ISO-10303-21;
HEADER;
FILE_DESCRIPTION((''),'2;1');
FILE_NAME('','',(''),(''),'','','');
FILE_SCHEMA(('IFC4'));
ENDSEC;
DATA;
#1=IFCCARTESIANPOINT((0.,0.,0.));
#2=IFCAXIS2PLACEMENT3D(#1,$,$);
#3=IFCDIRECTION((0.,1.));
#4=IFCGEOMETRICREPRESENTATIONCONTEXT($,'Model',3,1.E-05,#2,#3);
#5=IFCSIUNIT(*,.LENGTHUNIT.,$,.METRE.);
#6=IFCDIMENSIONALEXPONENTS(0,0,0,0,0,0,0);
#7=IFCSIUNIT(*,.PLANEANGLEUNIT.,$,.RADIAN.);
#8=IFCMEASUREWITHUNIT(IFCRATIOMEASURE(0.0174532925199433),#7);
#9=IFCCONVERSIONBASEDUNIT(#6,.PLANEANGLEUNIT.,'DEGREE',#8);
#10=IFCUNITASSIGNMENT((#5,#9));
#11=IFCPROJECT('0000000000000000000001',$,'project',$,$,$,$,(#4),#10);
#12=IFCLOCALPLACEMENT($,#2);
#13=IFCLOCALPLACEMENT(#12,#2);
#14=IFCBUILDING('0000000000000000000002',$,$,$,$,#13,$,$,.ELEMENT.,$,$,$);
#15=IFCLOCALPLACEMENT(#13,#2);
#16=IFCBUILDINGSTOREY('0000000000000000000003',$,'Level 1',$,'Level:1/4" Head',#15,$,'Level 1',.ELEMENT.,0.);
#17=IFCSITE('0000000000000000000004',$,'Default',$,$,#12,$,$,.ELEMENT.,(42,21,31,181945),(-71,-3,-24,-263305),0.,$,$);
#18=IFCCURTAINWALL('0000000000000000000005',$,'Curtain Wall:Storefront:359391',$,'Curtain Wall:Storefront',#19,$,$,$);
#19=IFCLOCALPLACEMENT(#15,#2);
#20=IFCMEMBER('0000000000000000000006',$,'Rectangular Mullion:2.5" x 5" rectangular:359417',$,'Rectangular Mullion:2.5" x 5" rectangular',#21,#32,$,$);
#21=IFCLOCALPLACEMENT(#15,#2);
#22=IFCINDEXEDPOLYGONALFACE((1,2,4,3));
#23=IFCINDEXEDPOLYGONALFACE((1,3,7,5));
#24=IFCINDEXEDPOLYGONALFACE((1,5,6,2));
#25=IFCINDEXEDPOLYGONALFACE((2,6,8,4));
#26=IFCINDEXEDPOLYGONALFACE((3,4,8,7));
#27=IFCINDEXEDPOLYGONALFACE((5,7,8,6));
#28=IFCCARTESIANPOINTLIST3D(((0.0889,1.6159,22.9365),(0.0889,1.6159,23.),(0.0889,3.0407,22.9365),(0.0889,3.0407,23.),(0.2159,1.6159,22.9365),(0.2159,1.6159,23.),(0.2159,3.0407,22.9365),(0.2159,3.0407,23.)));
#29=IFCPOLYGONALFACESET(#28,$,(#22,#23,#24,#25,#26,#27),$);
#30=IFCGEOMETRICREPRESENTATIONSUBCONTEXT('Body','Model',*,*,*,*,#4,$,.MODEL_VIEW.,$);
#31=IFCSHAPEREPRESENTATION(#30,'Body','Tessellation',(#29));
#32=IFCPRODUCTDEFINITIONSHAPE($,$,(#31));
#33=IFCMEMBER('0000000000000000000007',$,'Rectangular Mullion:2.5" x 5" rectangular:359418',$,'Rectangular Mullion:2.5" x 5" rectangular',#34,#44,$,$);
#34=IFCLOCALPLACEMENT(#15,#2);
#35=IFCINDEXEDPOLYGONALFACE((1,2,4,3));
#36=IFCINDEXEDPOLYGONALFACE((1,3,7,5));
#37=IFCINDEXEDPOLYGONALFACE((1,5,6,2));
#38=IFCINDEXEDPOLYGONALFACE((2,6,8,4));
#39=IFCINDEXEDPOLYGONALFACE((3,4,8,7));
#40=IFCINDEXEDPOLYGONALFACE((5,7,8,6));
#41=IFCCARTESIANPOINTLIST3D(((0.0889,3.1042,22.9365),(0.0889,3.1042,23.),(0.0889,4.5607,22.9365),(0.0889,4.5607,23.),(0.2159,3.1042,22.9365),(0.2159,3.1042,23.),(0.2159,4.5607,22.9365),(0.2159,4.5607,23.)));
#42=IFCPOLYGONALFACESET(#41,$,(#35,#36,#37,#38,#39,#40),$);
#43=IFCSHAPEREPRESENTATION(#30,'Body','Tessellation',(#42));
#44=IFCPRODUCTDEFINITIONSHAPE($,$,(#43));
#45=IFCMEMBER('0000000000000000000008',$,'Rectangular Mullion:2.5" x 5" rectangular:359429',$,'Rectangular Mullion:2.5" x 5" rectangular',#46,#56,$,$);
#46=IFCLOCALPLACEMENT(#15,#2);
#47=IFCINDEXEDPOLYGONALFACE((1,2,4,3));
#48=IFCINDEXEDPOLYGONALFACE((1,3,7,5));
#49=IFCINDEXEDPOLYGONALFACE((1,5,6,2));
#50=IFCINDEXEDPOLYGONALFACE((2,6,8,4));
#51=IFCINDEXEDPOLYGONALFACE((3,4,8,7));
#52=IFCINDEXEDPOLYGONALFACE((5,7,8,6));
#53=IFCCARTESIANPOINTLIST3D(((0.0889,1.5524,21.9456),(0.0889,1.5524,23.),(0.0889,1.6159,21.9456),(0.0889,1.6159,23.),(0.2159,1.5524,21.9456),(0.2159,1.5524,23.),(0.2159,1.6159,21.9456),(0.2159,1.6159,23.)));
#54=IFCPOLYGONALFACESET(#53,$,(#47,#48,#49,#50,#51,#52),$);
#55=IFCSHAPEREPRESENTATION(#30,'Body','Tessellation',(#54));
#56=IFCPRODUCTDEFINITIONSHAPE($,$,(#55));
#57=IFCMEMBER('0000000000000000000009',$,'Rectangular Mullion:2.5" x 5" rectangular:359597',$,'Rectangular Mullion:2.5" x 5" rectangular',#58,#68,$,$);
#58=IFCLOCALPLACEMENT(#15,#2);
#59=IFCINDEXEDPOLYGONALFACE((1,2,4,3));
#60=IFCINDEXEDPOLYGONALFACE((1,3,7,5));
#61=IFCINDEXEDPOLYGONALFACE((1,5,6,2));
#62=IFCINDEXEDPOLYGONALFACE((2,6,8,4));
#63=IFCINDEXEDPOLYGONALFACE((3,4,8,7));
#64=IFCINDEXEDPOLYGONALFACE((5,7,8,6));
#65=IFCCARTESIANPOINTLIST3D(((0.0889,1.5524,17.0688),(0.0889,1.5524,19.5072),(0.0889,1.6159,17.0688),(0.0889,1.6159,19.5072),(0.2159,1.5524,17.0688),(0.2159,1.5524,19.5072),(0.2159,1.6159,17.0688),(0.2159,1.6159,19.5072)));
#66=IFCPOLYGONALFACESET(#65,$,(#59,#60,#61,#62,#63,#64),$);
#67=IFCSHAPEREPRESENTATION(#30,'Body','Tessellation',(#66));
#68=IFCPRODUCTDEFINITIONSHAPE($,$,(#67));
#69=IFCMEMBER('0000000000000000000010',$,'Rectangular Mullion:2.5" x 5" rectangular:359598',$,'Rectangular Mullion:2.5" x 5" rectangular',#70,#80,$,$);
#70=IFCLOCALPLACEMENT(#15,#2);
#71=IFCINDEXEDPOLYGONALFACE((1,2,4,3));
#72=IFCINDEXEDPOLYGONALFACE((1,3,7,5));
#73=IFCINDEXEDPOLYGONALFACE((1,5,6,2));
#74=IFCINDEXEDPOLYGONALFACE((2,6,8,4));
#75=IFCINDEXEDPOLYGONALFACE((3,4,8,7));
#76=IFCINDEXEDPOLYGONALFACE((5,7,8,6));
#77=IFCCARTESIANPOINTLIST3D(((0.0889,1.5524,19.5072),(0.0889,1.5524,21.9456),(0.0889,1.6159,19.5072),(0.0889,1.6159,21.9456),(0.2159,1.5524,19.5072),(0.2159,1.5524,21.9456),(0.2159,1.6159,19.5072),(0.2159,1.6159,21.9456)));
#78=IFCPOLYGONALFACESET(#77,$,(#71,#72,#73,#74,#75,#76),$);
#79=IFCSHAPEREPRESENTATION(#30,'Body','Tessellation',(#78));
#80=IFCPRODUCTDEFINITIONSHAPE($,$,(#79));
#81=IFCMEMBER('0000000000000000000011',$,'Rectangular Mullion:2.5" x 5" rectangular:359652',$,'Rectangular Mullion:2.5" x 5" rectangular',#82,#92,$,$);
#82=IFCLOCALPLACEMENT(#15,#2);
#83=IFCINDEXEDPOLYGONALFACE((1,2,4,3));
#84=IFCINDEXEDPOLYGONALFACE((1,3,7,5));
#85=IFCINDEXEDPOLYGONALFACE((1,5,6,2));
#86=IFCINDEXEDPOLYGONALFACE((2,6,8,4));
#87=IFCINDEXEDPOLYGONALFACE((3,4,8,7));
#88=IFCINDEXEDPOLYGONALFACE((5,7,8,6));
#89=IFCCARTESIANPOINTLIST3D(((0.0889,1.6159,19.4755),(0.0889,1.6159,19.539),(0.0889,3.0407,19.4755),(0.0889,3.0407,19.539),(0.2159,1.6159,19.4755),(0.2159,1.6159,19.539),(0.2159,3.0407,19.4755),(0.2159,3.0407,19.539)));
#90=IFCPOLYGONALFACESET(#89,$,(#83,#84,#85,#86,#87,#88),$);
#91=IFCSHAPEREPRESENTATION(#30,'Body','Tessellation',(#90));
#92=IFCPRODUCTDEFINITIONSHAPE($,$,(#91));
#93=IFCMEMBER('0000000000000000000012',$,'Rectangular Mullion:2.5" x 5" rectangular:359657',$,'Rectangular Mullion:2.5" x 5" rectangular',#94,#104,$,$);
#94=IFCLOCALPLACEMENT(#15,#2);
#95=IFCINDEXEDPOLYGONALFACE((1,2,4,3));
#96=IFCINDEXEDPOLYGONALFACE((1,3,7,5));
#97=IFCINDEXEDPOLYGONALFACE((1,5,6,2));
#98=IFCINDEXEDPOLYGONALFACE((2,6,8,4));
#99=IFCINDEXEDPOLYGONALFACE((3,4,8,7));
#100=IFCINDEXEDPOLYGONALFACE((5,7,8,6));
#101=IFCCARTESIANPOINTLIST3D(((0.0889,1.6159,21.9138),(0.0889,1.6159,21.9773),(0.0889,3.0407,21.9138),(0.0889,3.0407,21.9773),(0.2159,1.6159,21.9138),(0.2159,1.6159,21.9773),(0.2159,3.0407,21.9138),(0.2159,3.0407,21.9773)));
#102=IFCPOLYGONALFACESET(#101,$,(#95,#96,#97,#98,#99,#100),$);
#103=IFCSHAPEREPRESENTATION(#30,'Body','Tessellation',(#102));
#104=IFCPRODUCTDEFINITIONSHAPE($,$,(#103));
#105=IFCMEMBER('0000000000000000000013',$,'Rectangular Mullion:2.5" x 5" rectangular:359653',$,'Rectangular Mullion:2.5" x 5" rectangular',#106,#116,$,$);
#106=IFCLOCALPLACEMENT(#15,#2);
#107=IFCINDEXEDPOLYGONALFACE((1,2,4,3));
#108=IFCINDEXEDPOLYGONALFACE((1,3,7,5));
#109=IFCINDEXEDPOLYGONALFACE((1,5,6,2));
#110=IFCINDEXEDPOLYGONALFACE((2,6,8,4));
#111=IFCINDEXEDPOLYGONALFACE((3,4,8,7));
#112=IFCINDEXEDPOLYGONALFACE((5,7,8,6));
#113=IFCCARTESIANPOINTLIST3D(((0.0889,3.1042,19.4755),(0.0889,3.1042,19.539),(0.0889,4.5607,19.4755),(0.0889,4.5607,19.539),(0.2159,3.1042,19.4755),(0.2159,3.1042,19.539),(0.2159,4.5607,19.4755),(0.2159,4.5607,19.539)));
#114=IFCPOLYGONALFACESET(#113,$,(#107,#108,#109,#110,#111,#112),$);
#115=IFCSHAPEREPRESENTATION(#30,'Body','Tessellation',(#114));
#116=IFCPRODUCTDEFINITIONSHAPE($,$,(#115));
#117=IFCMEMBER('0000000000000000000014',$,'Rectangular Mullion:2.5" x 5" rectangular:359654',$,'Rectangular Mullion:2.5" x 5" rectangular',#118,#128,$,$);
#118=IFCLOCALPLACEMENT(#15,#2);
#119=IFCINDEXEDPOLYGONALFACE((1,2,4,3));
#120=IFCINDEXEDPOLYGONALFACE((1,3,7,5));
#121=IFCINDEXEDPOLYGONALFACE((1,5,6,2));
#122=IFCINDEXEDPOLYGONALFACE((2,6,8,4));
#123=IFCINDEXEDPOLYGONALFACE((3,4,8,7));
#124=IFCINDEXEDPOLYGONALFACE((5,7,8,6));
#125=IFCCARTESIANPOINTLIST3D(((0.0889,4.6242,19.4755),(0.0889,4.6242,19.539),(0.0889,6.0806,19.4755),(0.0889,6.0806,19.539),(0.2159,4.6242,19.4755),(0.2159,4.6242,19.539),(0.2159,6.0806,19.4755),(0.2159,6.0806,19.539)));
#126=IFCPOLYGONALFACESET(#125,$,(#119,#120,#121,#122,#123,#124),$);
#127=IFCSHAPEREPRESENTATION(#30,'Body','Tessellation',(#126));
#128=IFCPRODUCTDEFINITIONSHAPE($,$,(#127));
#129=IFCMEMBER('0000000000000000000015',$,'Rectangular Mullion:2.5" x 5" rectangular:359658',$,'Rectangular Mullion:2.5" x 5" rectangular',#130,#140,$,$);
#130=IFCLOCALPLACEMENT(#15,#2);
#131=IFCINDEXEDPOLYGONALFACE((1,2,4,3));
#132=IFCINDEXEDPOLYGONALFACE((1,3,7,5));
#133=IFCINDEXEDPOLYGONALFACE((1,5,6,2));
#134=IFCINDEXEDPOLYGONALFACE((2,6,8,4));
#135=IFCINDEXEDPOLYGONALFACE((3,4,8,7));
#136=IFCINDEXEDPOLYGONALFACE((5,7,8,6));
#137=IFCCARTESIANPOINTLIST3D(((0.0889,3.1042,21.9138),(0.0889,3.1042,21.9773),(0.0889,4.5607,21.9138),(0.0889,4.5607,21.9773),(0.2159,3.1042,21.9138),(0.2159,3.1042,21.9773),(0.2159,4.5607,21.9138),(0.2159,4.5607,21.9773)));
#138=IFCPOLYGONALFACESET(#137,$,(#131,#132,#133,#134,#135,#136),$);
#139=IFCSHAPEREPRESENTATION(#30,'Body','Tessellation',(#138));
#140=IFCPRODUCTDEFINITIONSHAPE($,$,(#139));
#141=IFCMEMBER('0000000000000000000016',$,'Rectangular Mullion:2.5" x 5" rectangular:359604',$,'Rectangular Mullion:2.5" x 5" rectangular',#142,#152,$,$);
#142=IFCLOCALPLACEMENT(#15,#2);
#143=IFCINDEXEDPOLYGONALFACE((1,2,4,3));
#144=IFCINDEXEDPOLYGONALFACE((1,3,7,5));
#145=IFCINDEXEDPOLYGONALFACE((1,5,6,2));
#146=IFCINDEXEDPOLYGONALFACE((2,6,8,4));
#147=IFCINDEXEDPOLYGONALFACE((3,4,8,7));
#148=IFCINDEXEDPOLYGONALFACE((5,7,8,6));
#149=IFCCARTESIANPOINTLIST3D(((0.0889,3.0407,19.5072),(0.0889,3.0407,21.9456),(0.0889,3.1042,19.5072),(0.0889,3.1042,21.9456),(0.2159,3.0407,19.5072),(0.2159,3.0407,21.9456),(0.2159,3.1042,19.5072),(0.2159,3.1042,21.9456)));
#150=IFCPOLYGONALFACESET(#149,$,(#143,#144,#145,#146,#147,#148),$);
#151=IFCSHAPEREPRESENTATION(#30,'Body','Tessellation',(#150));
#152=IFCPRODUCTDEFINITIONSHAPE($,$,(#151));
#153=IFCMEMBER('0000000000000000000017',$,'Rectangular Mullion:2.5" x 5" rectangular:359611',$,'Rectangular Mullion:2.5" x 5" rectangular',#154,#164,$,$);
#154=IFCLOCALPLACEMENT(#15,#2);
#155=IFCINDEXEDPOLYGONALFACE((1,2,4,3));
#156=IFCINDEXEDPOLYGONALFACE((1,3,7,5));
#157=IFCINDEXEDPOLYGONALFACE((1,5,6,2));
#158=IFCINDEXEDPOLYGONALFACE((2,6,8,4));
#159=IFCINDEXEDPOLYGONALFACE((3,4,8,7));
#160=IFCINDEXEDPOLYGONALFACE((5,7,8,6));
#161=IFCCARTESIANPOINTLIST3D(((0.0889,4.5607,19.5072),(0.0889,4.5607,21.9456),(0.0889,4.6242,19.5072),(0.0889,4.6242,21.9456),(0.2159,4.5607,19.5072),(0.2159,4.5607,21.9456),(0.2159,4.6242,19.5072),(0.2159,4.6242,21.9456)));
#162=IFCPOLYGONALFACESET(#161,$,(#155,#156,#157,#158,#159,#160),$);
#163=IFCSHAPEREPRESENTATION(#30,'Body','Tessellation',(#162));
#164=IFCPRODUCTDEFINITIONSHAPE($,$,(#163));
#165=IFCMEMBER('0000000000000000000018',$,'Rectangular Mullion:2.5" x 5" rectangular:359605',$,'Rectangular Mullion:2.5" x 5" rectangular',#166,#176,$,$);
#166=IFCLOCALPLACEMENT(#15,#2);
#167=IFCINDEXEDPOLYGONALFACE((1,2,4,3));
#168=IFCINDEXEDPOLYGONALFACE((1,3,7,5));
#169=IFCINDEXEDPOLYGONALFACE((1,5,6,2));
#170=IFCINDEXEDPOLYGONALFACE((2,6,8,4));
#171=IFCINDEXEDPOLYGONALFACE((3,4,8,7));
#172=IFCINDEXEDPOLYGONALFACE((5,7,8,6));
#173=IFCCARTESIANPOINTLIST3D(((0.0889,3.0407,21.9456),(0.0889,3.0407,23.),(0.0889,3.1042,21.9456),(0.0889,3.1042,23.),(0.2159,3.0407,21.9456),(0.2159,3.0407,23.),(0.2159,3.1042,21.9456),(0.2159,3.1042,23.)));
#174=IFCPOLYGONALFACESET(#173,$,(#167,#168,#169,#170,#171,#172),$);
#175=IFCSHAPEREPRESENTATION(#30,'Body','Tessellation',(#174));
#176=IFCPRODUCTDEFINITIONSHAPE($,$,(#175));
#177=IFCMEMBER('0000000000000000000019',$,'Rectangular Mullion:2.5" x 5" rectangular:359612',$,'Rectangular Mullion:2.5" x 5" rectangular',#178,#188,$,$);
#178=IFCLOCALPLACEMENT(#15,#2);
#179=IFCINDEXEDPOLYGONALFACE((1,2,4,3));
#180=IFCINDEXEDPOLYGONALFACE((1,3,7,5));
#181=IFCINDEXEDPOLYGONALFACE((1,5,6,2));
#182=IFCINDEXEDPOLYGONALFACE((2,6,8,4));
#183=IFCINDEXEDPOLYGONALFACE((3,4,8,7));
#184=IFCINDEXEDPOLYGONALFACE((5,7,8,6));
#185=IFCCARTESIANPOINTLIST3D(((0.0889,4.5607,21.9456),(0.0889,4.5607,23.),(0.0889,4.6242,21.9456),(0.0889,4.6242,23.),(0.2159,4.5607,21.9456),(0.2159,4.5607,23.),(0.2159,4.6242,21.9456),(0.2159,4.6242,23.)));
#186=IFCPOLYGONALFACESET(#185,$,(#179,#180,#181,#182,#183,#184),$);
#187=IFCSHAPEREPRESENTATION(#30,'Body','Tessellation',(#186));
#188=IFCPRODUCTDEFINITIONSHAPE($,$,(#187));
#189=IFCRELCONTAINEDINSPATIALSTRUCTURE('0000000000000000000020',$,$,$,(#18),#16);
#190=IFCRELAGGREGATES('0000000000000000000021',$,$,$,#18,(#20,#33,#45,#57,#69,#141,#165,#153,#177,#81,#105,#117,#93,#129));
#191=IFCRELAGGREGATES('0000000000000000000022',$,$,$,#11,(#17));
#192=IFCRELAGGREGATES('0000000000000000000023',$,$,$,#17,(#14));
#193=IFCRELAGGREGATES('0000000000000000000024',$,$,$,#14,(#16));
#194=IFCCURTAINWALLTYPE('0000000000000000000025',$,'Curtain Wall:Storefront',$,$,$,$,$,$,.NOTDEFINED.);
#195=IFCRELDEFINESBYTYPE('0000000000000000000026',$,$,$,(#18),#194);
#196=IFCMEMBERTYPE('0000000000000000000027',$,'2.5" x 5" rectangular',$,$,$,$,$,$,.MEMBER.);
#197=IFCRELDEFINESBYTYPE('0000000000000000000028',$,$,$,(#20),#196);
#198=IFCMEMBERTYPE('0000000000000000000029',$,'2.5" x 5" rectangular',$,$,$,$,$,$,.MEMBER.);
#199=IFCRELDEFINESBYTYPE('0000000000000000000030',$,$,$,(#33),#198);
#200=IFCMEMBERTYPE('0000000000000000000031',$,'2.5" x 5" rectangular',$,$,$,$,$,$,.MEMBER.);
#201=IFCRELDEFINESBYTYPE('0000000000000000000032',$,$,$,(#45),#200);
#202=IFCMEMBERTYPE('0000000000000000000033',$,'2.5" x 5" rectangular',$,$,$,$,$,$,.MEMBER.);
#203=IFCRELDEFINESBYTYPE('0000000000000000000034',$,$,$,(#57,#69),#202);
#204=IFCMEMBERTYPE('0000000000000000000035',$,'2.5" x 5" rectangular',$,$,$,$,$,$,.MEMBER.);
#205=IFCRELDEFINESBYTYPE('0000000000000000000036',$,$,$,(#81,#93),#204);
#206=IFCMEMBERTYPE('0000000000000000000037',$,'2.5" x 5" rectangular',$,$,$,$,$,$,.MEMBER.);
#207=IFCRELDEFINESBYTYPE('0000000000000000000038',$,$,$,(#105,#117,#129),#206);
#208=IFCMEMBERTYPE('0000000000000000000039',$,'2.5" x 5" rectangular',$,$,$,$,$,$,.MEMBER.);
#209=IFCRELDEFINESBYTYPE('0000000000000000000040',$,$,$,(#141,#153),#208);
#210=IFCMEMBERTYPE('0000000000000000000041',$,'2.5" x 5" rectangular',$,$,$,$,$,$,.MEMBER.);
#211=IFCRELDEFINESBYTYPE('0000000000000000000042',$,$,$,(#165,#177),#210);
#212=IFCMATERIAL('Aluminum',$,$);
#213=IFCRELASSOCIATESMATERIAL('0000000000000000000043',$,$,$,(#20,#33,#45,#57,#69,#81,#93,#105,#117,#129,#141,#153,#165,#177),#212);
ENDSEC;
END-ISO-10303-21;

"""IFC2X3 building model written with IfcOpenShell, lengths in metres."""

from ifc_helpers import new_model, entity, si_unit, converted_unit, direction, frame, origin, origin_2d_with_axis, place, context, subcontext, project, spatial, rectangle, extrude, source, transform, mapped, material, type_object, type_shapes, element, aggregate, save


model = new_model("IFC2X3")

# Units and contexts
model_context = context("Model", 3, precision=1e-05, world=origin(), true_north=direction((0.0, 1.0)))
body_context = subcontext(model_context, "Body", "Model", "MODEL_VIEW")
ifc_project = project(units=[si_unit("LENGTHUNIT", "METRE"), converted_unit("PLANEANGLEUNIT", "DEGREE", entity("IfcRatioMeasure", 0.0174532925199433), si_unit("PLANEANGLEUNIT", "RADIAN"), dimensions=[0, 0, 0, 0, 0, 0, 0])], contexts=[model_context])

# Site, building, storey
site_placement = place(None, origin())
site = spatial("IfcSite", under=ifc_project, at=site_placement, Name="Default", CompositionType="ELEMENT", RefLatitude=(42, 21, 31, 181945), RefLongitude=(-71, -3, -24, -263305), RefElevation=0.0)
building_placement = place(site_placement, origin())
building = spatial("IfcBuilding", under=site, at=building_placement, CompositionType="ELEMENT")
storey_placement = place(building_placement, origin())
storey = spatial("IfcBuildingStorey", under=building, at=storey_placement, Name="Level 1", ObjectType="Level:1/4\" Head", LongName="Level 1", CompositionType="ELEMENT", Elevation=0.0)

# Curtain wall, members
curtain_wall_type = type_object("IfcCurtainWallType", Name="Curtain Wall:Storefront", PredefinedType="NOTDEFINED")
curtain_wall_placement = place(storey_placement, origin())
curtain_wall = element("IfcCurtainWall", 1, at=curtain_wall_placement, inside=storey, type_object=curtain_wall_type, Name="Curtain Wall:Storefront:359391", ObjectType="Curtain Wall:Storefront")
ifc_material_1 = material(Name="Aluminum")
member_type_1 = type_object("IfcMemberType", Name="2.5\" x 5\" rectangular", PredefinedType="MEMBER")
shared_shape_1 = source(origin(), body_context, "Body", "SweptSolid", [
    extrude(rectangle(XDim=0.127, YDim=0.0635, at=origin_2d_with_axis()), frame((-0.0318, 0.0, -1.4248), z_axis=(0.0, 0.0, 1.0), x_axis=(0.0, -1.0, 0.0)), (0.0, 0.0, 1.0), 1.4248),
])
type_shapes(member_type_1, [shared_shape_1])
member_1_placement = place(storey_placement, frame((0.1524, 3.0407, 23.0), z_axis=(0.0, 1.0, 0.0), x_axis=(0.0, 0.0, 1.0)))
member_1 = element("IfcMember", 2, at=member_1_placement, type_object=member_type_1, material=ifc_material_1, Name="Rectangular Mullion:2.5\" x 5\" rectangular:359417", ObjectType="Rectangular Mullion:2.5\" x 5\" rectangular", context=body_context, shape_type="MappedRepresentation", body=[
    mapped(shared_shape_1, transform((0.0, 0.0, 0.0), scale=1.0)),
])
member_type_2 = type_object("IfcMemberType", Name="2.5\" x 5\" rectangular", PredefinedType="MEMBER")
shared_shape_2 = source(origin(), body_context, "Body", "SweptSolid", [
    extrude(rectangle(XDim=0.127, YDim=0.0635, at=origin_2d_with_axis()), frame((-0.0318, 0.0, -1.4565), z_axis=(0.0, 0.0, 1.0), x_axis=(0.0, -1.0, 0.0)), (0.0, 0.0, 1.0), 1.4565),
])
type_shapes(member_type_2, [shared_shape_2])
member_2_placement = place(storey_placement, frame((0.1524, 4.5607, 23.0), z_axis=(0.0, 1.0, 0.0), x_axis=(0.0, 0.0, 1.0)))
member_2 = element("IfcMember", 3, at=member_2_placement, type_object=member_type_2, material=ifc_material_1, Name="Rectangular Mullion:2.5\" x 5\" rectangular:359418", ObjectType="Rectangular Mullion:2.5\" x 5\" rectangular", context=body_context, shape_type="MappedRepresentation", body=[
    mapped(shared_shape_2, transform((0.0, 0.0, 0.0), scale=1.0)),
])
member_type_3 = type_object("IfcMemberType", Name="2.5\" x 5\" rectangular", PredefinedType="MEMBER")
shared_shape_3 = source(origin(), body_context, "Body", "SweptSolid", [
    extrude(rectangle(XDim=0.127, YDim=0.0635, at=origin_2d_with_axis()), frame((-0.0318, 0.0, -1.0544), z_axis=(0.0, 0.0, 1.0), x_axis=(0.0, -1.0, 0.0)), (0.0, 0.0, 1.0), 1.0544),
])
type_shapes(member_type_3, [shared_shape_3])
member_3_placement = place(storey_placement, frame((0.1524, 1.5524, 23.0), z_axis=(0.0, 0.0, 1.0), x_axis=(0.0, -1.0, 0.0)))
member_3 = element("IfcMember", 4, at=member_3_placement, type_object=member_type_3, material=ifc_material_1, Name="Rectangular Mullion:2.5\" x 5\" rectangular:359429", ObjectType="Rectangular Mullion:2.5\" x 5\" rectangular", context=body_context, shape_type="MappedRepresentation", body=[
    mapped(shared_shape_3, transform((0.0, 0.0, 0.0), scale=1.0)),
])
member_type_4 = type_object("IfcMemberType", Name="2.5\" x 5\" rectangular", PredefinedType="MEMBER")
shared_shape_4 = source(origin(), body_context, "Body", "SweptSolid", [
    extrude(rectangle(XDim=0.127, YDim=0.0635, at=origin_2d_with_axis()), frame((-0.0318, 0.0, -2.4384), z_axis=(0.0, 0.0, 1.0), x_axis=(0.0, -1.0, 0.0)), (0.0, 0.0, 1.0), 2.4384),
])
type_shapes(member_type_4, [shared_shape_4])
member_4_placement = place(storey_placement, frame((0.1524, 1.5524, 19.5072), z_axis=(0.0, 0.0, 1.0), x_axis=(0.0, -1.0, 0.0)))
member_4 = element("IfcMember", 5, at=member_4_placement, type_object=member_type_4, material=ifc_material_1, Name="Rectangular Mullion:2.5\" x 5\" rectangular:359597", ObjectType="Rectangular Mullion:2.5\" x 5\" rectangular", context=body_context, shape_type="MappedRepresentation", body=[
    mapped(shared_shape_4, transform((0.0, 0.0, 0.0), scale=1.0)),
])
member_5_placement = place(storey_placement, frame((0.1524, 1.5524, 21.9456), z_axis=(0.0, 0.0, 1.0), x_axis=(0.0, -1.0, 0.0)))
member_5 = element("IfcMember", 6, at=member_5_placement, type_object=member_type_4, material=ifc_material_1, Name="Rectangular Mullion:2.5\" x 5\" rectangular:359598", ObjectType="Rectangular Mullion:2.5\" x 5\" rectangular", context=body_context, shape_type="MappedRepresentation", body=[
    mapped(shared_shape_4, transform((0.0, 0.0, 0.0), scale=1.0)),
])
member_type_5 = type_object("IfcMemberType", Name="2.5\" x 5\" rectangular", PredefinedType="MEMBER")
shared_shape_5 = source(origin(), body_context, "Body", "SweptSolid", [
    extrude(rectangle(XDim=0.127, YDim=0.0635, at=origin_2d_with_axis()), frame((0.0, 0.0, -1.4248), z_axis=(0.0, 0.0, 1.0), x_axis=(0.0, -1.0, 0.0)), (0.0, 0.0, 1.0), 1.4248),
])
type_shapes(member_type_5, [shared_shape_5])
member_6_placement = place(storey_placement, frame((0.1524, 3.0407, 19.5072), z_axis=(0.0, 1.0, 0.0), x_axis=(0.0, 0.0, 1.0)))
member_6 = element("IfcMember", 7, at=member_6_placement, type_object=member_type_5, material=ifc_material_1, Name="Rectangular Mullion:2.5\" x 5\" rectangular:359652", ObjectType="Rectangular Mullion:2.5\" x 5\" rectangular", context=body_context, shape_type="MappedRepresentation", body=[
    mapped(shared_shape_5, transform((0.0, 0.0, 0.0), scale=1.0)),
])
member_7_placement = place(storey_placement, frame((0.1524, 3.0407, 21.9456), z_axis=(0.0, 1.0, 0.0), x_axis=(0.0, 0.0, 1.0)))
member_7 = element("IfcMember", 8, at=member_7_placement, type_object=member_type_5, material=ifc_material_1, Name="Rectangular Mullion:2.5\" x 5\" rectangular:359657", ObjectType="Rectangular Mullion:2.5\" x 5\" rectangular", context=body_context, shape_type="MappedRepresentation", body=[
    mapped(shared_shape_5, transform((0.0, 0.0, 0.0), scale=1.0)),
])
member_type_6 = type_object("IfcMemberType", Name="2.5\" x 5\" rectangular", PredefinedType="MEMBER")
shared_shape_6 = source(origin(), body_context, "Body", "SweptSolid", [
    extrude(rectangle(XDim=0.127, YDim=0.0635, at=origin_2d_with_axis()), frame((0.0, 0.0, -1.4565), z_axis=(0.0, 0.0, 1.0), x_axis=(0.0, -1.0, 0.0)), (0.0, 0.0, 1.0), 1.4565),
])
type_shapes(member_type_6, [shared_shape_6])
member_8_placement = place(storey_placement, frame((0.1524, 4.5607, 19.5072), z_axis=(0.0, 1.0, 0.0), x_axis=(0.0, 0.0, 1.0)))
member_8 = element("IfcMember", 9, at=member_8_placement, type_object=member_type_6, material=ifc_material_1, Name="Rectangular Mullion:2.5\" x 5\" rectangular:359653", ObjectType="Rectangular Mullion:2.5\" x 5\" rectangular", context=body_context, shape_type="MappedRepresentation", body=[
    mapped(shared_shape_6, transform((0.0, 0.0, 0.0), scale=1.0)),
])
member_9_placement = place(storey_placement, frame((0.1524, 6.0806, 19.5072), z_axis=(0.0, 1.0, 0.0), x_axis=(0.0, 0.0, 1.0)))
member_9 = element("IfcMember", 10, at=member_9_placement, type_object=member_type_6, material=ifc_material_1, Name="Rectangular Mullion:2.5\" x 5\" rectangular:359654", ObjectType="Rectangular Mullion:2.5\" x 5\" rectangular", context=body_context, shape_type="MappedRepresentation", body=[
    mapped(shared_shape_6, transform((0.0, 0.0, 0.0), scale=1.0)),
])
member_10_placement = place(storey_placement, frame((0.1524, 4.5607, 21.9456), z_axis=(0.0, 1.0, 0.0), x_axis=(0.0, 0.0, 1.0)))
member_10 = element("IfcMember", 11, at=member_10_placement, type_object=member_type_6, material=ifc_material_1, Name="Rectangular Mullion:2.5\" x 5\" rectangular:359658", ObjectType="Rectangular Mullion:2.5\" x 5\" rectangular", context=body_context, shape_type="MappedRepresentation", body=[
    mapped(shared_shape_6, transform((0.0, 0.0, 0.0), scale=1.0)),
])
member_type_7 = type_object("IfcMemberType", Name="2.5\" x 5\" rectangular", PredefinedType="MEMBER")
shared_shape_7 = source(origin(), body_context, "Body", "SweptSolid", [
    extrude(rectangle(XDim=0.127, YDim=0.0635, at=origin_2d_with_axis()), frame((0.0, 0.0, -2.4384), z_axis=(0.0, 0.0, 1.0), x_axis=(0.0, -1.0, 0.0)), (0.0, 0.0, 1.0), 2.4384),
])
type_shapes(member_type_7, [shared_shape_7])
member_11_placement = place(storey_placement, frame((0.1524, 3.0724, 19.5072), z_axis=(0.0, 0.0, -1.0), x_axis=(0.0, 1.0, 0.0)))
member_11 = element("IfcMember", 12, at=member_11_placement, type_object=member_type_7, material=ifc_material_1, Name="Rectangular Mullion:2.5\" x 5\" rectangular:359604", ObjectType="Rectangular Mullion:2.5\" x 5\" rectangular", context=body_context, shape_type="MappedRepresentation", body=[
    mapped(shared_shape_7, transform((0.0, 0.0, 0.0), scale=1.0)),
])
member_12_placement = place(storey_placement, frame((0.1524, 4.5924, 19.5072), z_axis=(0.0, 0.0, -1.0), x_axis=(0.0, 1.0, 0.0)))
member_12 = element("IfcMember", 13, at=member_12_placement, type_object=member_type_7, material=ifc_material_1, Name="Rectangular Mullion:2.5\" x 5\" rectangular:359611", ObjectType="Rectangular Mullion:2.5\" x 5\" rectangular", context=body_context, shape_type="MappedRepresentation", body=[
    mapped(shared_shape_7, transform((0.0, 0.0, 0.0), scale=1.0)),
])
member_type_8 = type_object("IfcMemberType", Name="2.5\" x 5\" rectangular", PredefinedType="MEMBER")
shared_shape_8 = source(origin(), body_context, "Body", "SweptSolid", [
    extrude(rectangle(XDim=0.127, YDim=0.0635, at=origin_2d_with_axis()), frame((0.0, 0.0, -1.0544), z_axis=(0.0, 0.0, 1.0), x_axis=(0.0, -1.0, 0.0)), (0.0, 0.0, 1.0), 1.0544),
])
type_shapes(member_type_8, [shared_shape_8])
member_13_placement = place(storey_placement, frame((0.1524, 3.0724, 21.9456), z_axis=(0.0, 0.0, -1.0), x_axis=(0.0, 1.0, 0.0)))
member_13 = element("IfcMember", 14, at=member_13_placement, type_object=member_type_8, material=ifc_material_1, Name="Rectangular Mullion:2.5\" x 5\" rectangular:359605", ObjectType="Rectangular Mullion:2.5\" x 5\" rectangular", context=body_context, shape_type="MappedRepresentation", body=[
    mapped(shared_shape_8, transform((0.0, 0.0, 0.0), scale=1.0)),
])
member_14_placement = place(storey_placement, frame((0.1524, 4.5924, 21.9456), z_axis=(0.0, 0.0, -1.0), x_axis=(0.0, 1.0, 0.0)))
member_14 = element("IfcMember", 15, at=member_14_placement, type_object=member_type_8, material=ifc_material_1, Name="Rectangular Mullion:2.5\" x 5\" rectangular:359612", ObjectType="Rectangular Mullion:2.5\" x 5\" rectangular", context=body_context, shape_type="MappedRepresentation", body=[
    mapped(shared_shape_8, transform((0.0, 0.0, 0.0), scale=1.0)),
])
aggregate(curtain_wall, [member_1, member_2, member_3, member_4, member_5, member_11, member_13, member_12, member_14, member_6, member_8, member_9, member_7, member_10])

save(model, "model.ifc")
